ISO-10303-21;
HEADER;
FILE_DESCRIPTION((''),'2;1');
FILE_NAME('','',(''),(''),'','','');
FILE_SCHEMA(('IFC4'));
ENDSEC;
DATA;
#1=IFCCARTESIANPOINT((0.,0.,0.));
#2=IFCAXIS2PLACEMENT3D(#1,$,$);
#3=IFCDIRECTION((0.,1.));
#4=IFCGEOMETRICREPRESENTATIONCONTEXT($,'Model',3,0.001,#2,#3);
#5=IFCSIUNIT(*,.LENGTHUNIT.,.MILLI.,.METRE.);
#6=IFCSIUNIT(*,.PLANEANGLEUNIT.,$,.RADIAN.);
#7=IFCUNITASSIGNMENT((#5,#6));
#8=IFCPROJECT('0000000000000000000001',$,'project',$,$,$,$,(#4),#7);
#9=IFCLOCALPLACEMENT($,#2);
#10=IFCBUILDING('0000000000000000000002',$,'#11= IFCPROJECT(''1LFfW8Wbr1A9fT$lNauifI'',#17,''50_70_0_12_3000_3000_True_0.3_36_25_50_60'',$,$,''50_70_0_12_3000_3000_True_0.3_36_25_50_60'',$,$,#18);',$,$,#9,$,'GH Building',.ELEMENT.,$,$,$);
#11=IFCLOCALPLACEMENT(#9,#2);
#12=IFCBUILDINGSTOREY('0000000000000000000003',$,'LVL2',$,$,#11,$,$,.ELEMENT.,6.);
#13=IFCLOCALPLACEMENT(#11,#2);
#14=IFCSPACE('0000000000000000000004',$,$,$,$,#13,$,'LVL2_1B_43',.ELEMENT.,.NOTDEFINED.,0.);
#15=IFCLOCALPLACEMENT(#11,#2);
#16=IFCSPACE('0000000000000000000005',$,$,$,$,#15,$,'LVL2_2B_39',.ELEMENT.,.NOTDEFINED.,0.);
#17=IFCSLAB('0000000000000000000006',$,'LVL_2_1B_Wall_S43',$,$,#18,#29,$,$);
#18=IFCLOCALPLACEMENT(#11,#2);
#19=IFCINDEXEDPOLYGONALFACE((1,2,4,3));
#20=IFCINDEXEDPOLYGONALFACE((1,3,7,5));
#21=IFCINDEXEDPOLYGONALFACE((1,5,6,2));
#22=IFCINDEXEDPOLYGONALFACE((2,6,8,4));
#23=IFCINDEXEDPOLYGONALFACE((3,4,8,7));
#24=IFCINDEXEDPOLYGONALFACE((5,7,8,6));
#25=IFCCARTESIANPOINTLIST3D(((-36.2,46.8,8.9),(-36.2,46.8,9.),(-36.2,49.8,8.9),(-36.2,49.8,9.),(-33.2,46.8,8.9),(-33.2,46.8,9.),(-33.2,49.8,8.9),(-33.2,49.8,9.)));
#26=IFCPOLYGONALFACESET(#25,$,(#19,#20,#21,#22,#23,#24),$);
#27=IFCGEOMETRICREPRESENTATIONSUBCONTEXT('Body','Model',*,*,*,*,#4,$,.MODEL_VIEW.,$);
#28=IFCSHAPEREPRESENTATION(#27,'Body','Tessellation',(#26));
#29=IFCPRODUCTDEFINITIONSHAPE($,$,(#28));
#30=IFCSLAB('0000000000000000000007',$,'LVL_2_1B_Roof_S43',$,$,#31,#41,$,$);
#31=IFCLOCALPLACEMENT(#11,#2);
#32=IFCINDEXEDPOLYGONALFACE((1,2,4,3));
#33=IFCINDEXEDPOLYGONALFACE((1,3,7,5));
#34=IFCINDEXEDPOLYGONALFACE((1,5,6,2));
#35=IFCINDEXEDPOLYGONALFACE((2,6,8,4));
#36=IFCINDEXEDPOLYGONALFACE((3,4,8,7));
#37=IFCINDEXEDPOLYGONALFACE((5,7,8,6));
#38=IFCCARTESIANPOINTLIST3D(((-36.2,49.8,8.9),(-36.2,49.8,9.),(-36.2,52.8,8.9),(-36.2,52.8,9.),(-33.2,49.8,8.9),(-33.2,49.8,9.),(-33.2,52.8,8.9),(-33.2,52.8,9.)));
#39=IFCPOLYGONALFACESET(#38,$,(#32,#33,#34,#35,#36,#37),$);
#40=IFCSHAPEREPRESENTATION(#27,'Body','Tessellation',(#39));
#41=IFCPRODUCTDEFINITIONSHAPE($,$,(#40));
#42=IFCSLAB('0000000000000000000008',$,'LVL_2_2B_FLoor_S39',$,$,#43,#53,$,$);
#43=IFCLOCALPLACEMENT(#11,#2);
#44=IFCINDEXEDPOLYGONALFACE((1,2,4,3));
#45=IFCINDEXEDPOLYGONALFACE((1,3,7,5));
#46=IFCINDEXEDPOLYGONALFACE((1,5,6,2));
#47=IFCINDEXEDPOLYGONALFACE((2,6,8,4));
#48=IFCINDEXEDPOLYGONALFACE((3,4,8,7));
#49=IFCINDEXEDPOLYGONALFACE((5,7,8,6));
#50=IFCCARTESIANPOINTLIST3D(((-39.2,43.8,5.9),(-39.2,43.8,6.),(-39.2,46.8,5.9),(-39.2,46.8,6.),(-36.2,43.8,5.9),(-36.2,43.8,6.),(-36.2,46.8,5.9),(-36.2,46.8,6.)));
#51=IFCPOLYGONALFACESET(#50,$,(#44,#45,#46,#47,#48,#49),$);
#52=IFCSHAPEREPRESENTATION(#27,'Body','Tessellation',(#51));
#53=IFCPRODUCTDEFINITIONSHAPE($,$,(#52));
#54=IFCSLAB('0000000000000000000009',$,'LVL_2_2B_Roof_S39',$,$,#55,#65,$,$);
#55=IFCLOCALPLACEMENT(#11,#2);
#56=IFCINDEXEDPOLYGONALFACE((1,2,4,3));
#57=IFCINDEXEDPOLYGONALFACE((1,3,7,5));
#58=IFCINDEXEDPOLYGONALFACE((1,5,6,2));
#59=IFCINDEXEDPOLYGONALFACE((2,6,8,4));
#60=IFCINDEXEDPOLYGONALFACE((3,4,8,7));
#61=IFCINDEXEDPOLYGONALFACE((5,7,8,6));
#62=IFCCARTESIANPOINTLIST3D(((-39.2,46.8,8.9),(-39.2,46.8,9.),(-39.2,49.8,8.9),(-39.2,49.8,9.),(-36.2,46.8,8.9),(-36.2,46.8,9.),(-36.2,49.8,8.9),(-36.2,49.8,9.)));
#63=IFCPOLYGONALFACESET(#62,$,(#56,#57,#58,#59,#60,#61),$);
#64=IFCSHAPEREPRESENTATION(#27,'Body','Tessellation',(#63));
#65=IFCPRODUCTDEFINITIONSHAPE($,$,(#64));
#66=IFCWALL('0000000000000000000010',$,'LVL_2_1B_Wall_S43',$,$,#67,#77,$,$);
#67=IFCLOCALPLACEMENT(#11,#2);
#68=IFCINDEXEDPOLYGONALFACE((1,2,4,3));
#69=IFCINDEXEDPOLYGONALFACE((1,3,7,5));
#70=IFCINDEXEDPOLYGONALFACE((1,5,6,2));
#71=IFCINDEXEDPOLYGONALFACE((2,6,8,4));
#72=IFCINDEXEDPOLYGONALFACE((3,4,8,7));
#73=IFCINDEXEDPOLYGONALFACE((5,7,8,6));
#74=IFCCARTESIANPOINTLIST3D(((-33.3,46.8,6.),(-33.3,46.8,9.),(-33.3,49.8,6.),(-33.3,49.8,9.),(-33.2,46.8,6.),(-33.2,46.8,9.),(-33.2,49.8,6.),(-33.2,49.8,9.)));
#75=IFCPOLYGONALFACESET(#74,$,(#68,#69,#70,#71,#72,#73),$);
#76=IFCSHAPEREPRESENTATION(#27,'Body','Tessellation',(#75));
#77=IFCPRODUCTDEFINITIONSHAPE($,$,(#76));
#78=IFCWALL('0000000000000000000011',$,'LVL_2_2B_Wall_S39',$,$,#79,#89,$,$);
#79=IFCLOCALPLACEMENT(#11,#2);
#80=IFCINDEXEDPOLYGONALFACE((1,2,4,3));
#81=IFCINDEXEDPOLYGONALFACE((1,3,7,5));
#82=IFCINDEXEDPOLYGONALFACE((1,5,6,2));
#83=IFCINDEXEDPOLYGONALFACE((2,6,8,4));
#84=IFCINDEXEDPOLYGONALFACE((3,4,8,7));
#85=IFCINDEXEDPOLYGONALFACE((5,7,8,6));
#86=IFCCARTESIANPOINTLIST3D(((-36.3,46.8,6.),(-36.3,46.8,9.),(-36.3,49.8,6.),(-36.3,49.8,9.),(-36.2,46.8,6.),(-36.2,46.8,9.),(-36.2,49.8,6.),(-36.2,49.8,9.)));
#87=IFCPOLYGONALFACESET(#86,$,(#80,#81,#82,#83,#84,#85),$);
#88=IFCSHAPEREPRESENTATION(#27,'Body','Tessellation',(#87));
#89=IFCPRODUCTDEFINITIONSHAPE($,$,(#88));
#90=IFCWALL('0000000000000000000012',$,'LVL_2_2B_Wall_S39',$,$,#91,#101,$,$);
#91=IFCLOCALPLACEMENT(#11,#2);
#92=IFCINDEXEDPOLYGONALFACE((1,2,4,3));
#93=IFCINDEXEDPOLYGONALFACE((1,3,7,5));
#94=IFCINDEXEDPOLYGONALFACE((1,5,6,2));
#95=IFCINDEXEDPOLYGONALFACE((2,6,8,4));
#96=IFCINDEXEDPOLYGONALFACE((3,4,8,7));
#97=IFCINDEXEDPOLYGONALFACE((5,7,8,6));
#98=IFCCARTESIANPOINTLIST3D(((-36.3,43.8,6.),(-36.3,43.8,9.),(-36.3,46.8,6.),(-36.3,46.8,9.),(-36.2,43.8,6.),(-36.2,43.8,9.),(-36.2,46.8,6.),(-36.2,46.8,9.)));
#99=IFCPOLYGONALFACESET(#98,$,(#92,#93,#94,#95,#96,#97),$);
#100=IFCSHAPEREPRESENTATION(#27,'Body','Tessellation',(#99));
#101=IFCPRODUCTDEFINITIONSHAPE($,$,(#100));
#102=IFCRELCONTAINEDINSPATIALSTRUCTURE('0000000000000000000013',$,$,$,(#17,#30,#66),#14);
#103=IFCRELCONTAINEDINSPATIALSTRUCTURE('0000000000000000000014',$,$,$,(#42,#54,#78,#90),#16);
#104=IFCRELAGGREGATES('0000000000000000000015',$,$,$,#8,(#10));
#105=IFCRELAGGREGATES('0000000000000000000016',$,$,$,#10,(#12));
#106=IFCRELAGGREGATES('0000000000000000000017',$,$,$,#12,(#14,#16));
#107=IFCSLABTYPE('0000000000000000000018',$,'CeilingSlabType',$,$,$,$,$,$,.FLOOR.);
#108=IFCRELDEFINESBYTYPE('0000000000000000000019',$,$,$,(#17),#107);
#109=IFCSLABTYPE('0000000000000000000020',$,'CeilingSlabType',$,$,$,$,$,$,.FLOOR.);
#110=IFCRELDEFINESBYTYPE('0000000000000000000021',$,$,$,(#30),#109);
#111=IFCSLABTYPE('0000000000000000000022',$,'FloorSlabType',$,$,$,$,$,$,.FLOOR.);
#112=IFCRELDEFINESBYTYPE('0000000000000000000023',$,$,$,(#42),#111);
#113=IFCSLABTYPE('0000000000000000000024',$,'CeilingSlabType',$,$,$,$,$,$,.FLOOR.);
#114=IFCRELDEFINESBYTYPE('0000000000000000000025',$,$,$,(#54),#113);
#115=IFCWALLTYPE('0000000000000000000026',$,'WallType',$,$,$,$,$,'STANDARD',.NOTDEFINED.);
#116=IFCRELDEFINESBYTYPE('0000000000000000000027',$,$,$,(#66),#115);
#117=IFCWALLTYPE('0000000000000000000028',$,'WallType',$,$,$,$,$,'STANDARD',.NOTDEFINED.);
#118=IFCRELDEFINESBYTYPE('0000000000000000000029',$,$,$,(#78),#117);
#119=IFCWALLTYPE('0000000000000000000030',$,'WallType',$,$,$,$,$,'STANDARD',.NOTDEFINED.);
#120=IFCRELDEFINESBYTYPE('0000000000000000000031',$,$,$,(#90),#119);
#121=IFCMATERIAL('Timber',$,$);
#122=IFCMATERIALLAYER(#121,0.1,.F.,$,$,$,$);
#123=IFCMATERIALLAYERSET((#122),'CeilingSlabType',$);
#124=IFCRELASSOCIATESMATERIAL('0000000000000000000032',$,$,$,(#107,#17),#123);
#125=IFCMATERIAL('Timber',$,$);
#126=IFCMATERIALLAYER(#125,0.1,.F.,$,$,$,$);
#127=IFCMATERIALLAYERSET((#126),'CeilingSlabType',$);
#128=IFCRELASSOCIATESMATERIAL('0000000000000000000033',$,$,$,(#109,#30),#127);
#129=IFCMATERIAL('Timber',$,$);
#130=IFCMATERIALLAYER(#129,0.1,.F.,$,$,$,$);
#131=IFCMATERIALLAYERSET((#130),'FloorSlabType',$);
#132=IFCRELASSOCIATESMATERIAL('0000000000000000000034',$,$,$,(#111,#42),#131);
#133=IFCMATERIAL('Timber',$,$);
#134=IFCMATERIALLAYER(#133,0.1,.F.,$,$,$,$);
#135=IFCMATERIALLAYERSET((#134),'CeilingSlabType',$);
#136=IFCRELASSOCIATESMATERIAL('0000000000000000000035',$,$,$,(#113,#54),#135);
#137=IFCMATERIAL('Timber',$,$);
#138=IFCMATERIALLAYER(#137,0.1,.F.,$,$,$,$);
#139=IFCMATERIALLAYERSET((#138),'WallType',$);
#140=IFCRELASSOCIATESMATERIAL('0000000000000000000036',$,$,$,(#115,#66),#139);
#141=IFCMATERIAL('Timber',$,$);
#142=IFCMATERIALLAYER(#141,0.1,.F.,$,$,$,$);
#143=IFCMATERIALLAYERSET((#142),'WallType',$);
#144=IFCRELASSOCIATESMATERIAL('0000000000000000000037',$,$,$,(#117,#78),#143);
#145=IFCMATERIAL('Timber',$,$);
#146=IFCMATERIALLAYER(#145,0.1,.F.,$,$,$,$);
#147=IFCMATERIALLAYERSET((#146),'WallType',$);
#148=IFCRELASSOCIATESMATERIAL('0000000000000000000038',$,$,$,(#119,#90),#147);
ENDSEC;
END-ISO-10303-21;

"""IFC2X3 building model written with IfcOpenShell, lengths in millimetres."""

from ifc_helpers import new_model, si_unit, direction, frame, frame_2d, origin, place, context, subcontext, project, spatial, rectangle, extrude, material, layer, layer_set, layer_usage, type_object, element, save


model = new_model("IFC2X3")

# Units and contexts
model_context = context("Model", 3, precision=0.001, world=origin(), true_north=direction((0.0, 1.0)))
body_context = subcontext(model_context, "Body", "Model", "MODEL_VIEW")
ifc_project = project(units=[si_unit("LENGTHUNIT", "METRE", prefix="MILLI"), si_unit("PLANEANGLEUNIT", "RADIAN")], contexts=[model_context])

# Building, storey
building_placement = place(None, origin())
building = spatial("IfcBuilding", under=ifc_project, at=building_placement, Name="#11= IFCPROJECT('1LFfW8Wbr1A9fT$lNauifI',#17,'50_70_0_12_3000_3000_True_0.3_36_25_50_60',$,$,'50_70_0_12_3000_3000_True_0.3_36_25_50_60',$,$,#18);", LongName="GH Building", CompositionType="ELEMENT")
storey_placement = place(building_placement, origin())
storey = spatial("IfcBuildingStorey", under=building, at=storey_placement, Name="LVL2", CompositionType="ELEMENT", Elevation=6.0)

# Shared definitions
space_1_placement = place(storey_placement, origin())
space_1 = spatial("IfcSpace", under=storey, at=space_1_placement, LongName="LVL2_1B_43", CompositionType="ELEMENT", InteriorOrExteriorSpace="NOTDEFINED", ElevationWithFlooring=0.0)

# Slabs
ifc_material_1 = material(Name="Timber")
ifc_layer_1 = layer(ifc_material_1, 0.1, ventilated=False)
ifc_layer_set_1 = layer_set([ifc_layer_1], Name="CeilingSlabType")
ifc_layer_usage_1 = layer_usage(ifc_layer_set_1, "AXIS3", "NEGATIVE", -0.1)
slab_type_1 = type_object("IfcSlabType", Name="CeilingSlabType", PredefinedType="FLOOR", material=ifc_layer_set_1)
slab_1_placement = place(space_1_placement, frame((-33.2, 46.8, 8.9), z_axis=(0.0, 0.0, 1.0), x_axis=(0.0, 1.0, 0.0)))
element("IfcSlab", 1, at=slab_1_placement, inside=space_1, type_object=slab_type_1, material=ifc_layer_usage_1, Name="LVL_2_1B_Wall_S43", context=body_context, shape_type="SweptSolid", body=[
    extrude(rectangle(XDim=3.0, YDim=3.0, at=frame_2d((1.5, 1.5))), origin(), (0.0, 0.0, 1.0), 0.1),
])
ifc_material_2 = material(Name="Timber")
ifc_layer_2 = layer(ifc_material_2, 0.1, ventilated=False)
ifc_layer_set_2 = layer_set([ifc_layer_2], Name="CeilingSlabType")
ifc_layer_usage_2 = layer_usage(ifc_layer_set_2, "AXIS3", "NEGATIVE", -0.1)
slab_type_2 = type_object("IfcSlabType", Name="CeilingSlabType", PredefinedType="FLOOR", material=ifc_layer_set_2)
slab_2_placement = place(space_1_placement, frame((-33.2, 49.8, 8.9), z_axis=(0.0, 0.0, 1.0), x_axis=(0.0, 1.0, 0.0)))
element("IfcSlab", 2, at=slab_2_placement, inside=space_1, type_object=slab_type_2, material=ifc_layer_usage_2, Name="LVL_2_1B_Roof_S43", context=body_context, shape_type="SweptSolid", body=[
    extrude(rectangle(XDim=3.0, YDim=3.0, at=frame_2d((1.5, 1.5))), origin(), (0.0, 0.0, 1.0), 0.1),
])

# Shared definitions
space_2_placement = place(storey_placement, origin())
space_2 = spatial("IfcSpace", under=storey, at=space_2_placement, LongName="LVL2_2B_39", CompositionType="ELEMENT", InteriorOrExteriorSpace="NOTDEFINED", ElevationWithFlooring=0.0)

# Slabs
ifc_material_3 = material(Name="Timber")
ifc_layer_3 = layer(ifc_material_3, 0.1, ventilated=False)
ifc_layer_set_3 = layer_set([ifc_layer_3], Name="FloorSlabType")
ifc_layer_usage_3 = layer_usage(ifc_layer_set_3, "AXIS3", "NEGATIVE", -0.1)
slab_type_3 = type_object("IfcSlabType", Name="FloorSlabType", PredefinedType="FLOOR", material=ifc_layer_set_3)
slab_3_placement = place(space_2_placement, frame((-36.2, 46.8, 5.9), z_axis=(0.0, 0.0, 1.0), x_axis=(-1.0, 0.0, 0.0)))
element("IfcSlab", 3, at=slab_3_placement, inside=space_2, type_object=slab_type_3, material=ifc_layer_usage_3, Name="LVL_2_2B_FLoor_S39", context=body_context, shape_type="SweptSolid", body=[
    extrude(rectangle(XDim=3.0, YDim=3.0, at=frame_2d((1.5, 1.5))), origin(), (0.0, 0.0, 1.0), 0.1),
])
ifc_material_4 = material(Name="Timber")
ifc_layer_4 = layer(ifc_material_4, 0.1, ventilated=False)
ifc_layer_set_4 = layer_set([ifc_layer_4], Name="CeilingSlabType")
ifc_layer_usage_4 = layer_usage(ifc_layer_set_4, "AXIS3", "NEGATIVE", -0.1)
slab_type_4 = type_object("IfcSlabType", Name="CeilingSlabType", PredefinedType="FLOOR", material=ifc_layer_set_4)
slab_4_placement = place(space_2_placement, frame((-36.2, 49.8, 8.9), z_axis=(0.0, 0.0, 1.0), x_axis=(-1.0, 0.0, 0.0)))
element("IfcSlab", 4, at=slab_4_placement, inside=space_2, type_object=slab_type_4, material=ifc_layer_usage_4, Name="LVL_2_2B_Roof_S39", context=body_context, shape_type="SweptSolid", body=[
    extrude(rectangle(XDim=3.0, YDim=3.0, at=frame_2d((1.5, 1.5))), origin(), (0.0, 0.0, 1.0), 0.1),
])

# Wall
ifc_material_5 = material(Name="Timber")
ifc_layer_5 = layer(ifc_material_5, 0.1, ventilated=False)
ifc_layer_set_5 = layer_set([ifc_layer_5], Name="WallType")
ifc_layer_usage_5 = layer_usage(ifc_layer_set_5, "AXIS2", "NEGATIVE", 0.0)
wall_type_1 = type_object("IfcWallType", Name="WallType", ElementType="STANDARD", PredefinedType="NOTDEFINED", material=ifc_layer_set_5)
wall_1_placement = place(space_1_placement, frame((-33.2, 49.8, 6.0), z_axis=(0.0, 0.0, 1.0), x_axis=(0.0, -1.0, 0.0)))
element("IfcWall", 5, at=wall_1_placement, inside=space_1, type_object=wall_type_1, material=ifc_layer_usage_5, Name="LVL_2_1B_Wall_S43", context=body_context, shape_type="SweptSolid", body=[
    extrude(rectangle(XDim=3.0, YDim=0.1, at=frame_2d((1.5, -0.1))), origin(), (0.0, 0.0, 1.0), 3.0),
])

# Walls
ifc_material_6 = material(Name="Timber")
ifc_layer_6 = layer(ifc_material_6, 0.1, ventilated=False)
ifc_layer_set_6 = layer_set([ifc_layer_6], Name="WallType")
ifc_layer_usage_6 = layer_usage(ifc_layer_set_6, "AXIS2", "NEGATIVE", 0.0)
wall_type_2 = type_object("IfcWallType", Name="WallType", ElementType="STANDARD", PredefinedType="NOTDEFINED", material=ifc_layer_set_6)
wall_2_placement = place(space_2_placement, frame((-36.2, 49.8, 6.0), z_axis=(0.0, 0.0, 1.0), x_axis=(0.0, -1.0, 0.0)))
element("IfcWall", 6, at=wall_2_placement, inside=space_2, type_object=wall_type_2, material=ifc_layer_usage_6, Name="LVL_2_2B_Wall_S39", context=body_context, shape_type="SweptSolid", body=[
    extrude(rectangle(XDim=3.0, YDim=0.1, at=frame_2d((1.5, -0.1))), origin(), (0.0, 0.0, 1.0), 3.0),
])
ifc_material_7 = material(Name="Timber")
ifc_layer_7 = layer(ifc_material_7, 0.1, ventilated=False)
ifc_layer_set_7 = layer_set([ifc_layer_7], Name="WallType")
ifc_layer_usage_7 = layer_usage(ifc_layer_set_7, "AXIS2", "NEGATIVE", 0.0)
wall_type_3 = type_object("IfcWallType", Name="WallType", ElementType="STANDARD", PredefinedType="NOTDEFINED", material=ifc_layer_set_7)
wall_3_placement = place(space_2_placement, frame((-36.2, 46.8, 6.0), z_axis=(0.0, 0.0, 1.0), x_axis=(0.0, -1.0, 0.0)))
element("IfcWall", 7, at=wall_3_placement, inside=space_2, type_object=wall_type_3, material=ifc_layer_usage_7, Name="LVL_2_2B_Wall_S39", context=body_context, shape_type="SweptSolid", body=[
    extrude(rectangle(XDim=3.0, YDim=0.1, at=frame_2d((1.5, -0.1))), origin(), (0.0, 0.0, 1.0), 3.0),
])

save(model, "model.ifc")
